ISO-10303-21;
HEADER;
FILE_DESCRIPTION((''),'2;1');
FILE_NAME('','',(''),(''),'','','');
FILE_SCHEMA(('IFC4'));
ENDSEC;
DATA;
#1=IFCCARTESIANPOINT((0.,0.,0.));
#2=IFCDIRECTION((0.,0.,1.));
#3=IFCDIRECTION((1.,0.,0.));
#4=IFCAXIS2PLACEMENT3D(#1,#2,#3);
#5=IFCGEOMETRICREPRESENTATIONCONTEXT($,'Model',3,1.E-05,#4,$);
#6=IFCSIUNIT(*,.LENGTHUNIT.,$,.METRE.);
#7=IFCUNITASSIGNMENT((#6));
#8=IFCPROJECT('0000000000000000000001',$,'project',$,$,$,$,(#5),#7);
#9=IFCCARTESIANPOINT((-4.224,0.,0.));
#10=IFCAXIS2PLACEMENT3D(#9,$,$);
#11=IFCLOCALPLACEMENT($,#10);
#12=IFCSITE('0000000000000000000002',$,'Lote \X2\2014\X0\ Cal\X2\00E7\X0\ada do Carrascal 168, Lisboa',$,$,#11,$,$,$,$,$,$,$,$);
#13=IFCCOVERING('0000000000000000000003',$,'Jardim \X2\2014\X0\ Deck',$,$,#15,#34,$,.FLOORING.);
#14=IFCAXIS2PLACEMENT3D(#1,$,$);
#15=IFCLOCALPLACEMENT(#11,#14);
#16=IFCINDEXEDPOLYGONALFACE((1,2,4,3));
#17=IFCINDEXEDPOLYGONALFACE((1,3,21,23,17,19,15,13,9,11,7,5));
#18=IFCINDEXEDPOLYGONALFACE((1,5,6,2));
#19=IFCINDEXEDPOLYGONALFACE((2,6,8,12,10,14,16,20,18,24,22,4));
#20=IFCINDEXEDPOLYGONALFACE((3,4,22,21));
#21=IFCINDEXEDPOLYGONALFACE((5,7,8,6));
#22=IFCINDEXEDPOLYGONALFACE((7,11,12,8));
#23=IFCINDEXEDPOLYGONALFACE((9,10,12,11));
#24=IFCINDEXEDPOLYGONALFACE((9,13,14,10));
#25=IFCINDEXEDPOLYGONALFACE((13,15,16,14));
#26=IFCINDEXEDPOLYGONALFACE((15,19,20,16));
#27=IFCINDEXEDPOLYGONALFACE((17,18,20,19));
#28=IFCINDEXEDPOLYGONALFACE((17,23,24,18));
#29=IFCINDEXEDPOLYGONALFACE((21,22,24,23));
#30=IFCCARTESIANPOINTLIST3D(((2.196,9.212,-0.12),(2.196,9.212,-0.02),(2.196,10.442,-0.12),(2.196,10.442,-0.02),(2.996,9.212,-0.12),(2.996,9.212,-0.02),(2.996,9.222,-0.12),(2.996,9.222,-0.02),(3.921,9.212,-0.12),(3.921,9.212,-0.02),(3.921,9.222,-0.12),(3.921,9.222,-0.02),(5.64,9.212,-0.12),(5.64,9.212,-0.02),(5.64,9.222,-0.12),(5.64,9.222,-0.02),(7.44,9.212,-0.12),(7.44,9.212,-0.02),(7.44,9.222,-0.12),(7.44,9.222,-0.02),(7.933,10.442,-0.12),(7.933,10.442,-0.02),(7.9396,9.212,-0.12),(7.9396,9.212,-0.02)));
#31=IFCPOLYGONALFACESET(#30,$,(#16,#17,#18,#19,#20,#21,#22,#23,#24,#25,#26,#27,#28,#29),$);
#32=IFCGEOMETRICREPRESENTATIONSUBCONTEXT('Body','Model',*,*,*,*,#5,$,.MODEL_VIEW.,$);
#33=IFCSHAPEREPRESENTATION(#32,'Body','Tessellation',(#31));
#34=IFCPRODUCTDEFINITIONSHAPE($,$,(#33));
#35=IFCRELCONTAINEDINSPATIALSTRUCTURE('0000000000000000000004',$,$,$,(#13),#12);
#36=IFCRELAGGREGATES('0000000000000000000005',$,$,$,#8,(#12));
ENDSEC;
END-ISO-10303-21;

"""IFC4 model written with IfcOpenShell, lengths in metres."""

from ifc_helpers import new_model, si_unit, frame, origin, origin_with_axes, place, context, subcontext, project, spatial, line, indexed_curve, outline, extrude, element, save


model = new_model("IFC4")

# Units and contexts
model_context = context("Model", 3, precision=1e-05, world=origin_with_axes())
body_context = subcontext(model_context, "Body", "Model", "MODEL_VIEW")
ifc_project = project(units=[si_unit("LENGTHUNIT", "METRE")], contexts=[model_context])

# Site
site_placement = place(None, frame((-4.224, 0.0, 0.0)))
site = spatial("IfcSite", under=ifc_project, at=site_placement, Name="Lote — Calçada do Carrascal 168, Lisboa")

# Covering
placement = place(site_placement, origin())
covering_placement = place(placement, frame((0.0, 0.0, -0.12), z_axis=(0.0, 0.0, 1.0), x_axis=(1.0, 0.0, 0.0)))
element("IfcCovering", 1, at=covering_placement, inside=site, Name="Jardim — Deck", PredefinedType="FLOORING", context=body_context, shape_type="SweptSolid", body=[
    extrude(outline(indexed_curve([(2.196, 10.442), (7.933, 10.442), (7.9396, 9.212), (7.44, 9.212), (7.44, 9.222), (5.64, 9.222), (5.64, 9.212), (3.921, 9.212), (3.921, 9.222), (2.996, 9.222), (2.996, 9.212), (2.196, 9.212)], segments=[line(1, 2, 3, 4, 5, 6, 7, 8, 9, 10, 11, 12, 1)])), origin_with_axes(), (0.0, 0.0, 1.0), 0.1),
])

save(model, "model.ifc")
